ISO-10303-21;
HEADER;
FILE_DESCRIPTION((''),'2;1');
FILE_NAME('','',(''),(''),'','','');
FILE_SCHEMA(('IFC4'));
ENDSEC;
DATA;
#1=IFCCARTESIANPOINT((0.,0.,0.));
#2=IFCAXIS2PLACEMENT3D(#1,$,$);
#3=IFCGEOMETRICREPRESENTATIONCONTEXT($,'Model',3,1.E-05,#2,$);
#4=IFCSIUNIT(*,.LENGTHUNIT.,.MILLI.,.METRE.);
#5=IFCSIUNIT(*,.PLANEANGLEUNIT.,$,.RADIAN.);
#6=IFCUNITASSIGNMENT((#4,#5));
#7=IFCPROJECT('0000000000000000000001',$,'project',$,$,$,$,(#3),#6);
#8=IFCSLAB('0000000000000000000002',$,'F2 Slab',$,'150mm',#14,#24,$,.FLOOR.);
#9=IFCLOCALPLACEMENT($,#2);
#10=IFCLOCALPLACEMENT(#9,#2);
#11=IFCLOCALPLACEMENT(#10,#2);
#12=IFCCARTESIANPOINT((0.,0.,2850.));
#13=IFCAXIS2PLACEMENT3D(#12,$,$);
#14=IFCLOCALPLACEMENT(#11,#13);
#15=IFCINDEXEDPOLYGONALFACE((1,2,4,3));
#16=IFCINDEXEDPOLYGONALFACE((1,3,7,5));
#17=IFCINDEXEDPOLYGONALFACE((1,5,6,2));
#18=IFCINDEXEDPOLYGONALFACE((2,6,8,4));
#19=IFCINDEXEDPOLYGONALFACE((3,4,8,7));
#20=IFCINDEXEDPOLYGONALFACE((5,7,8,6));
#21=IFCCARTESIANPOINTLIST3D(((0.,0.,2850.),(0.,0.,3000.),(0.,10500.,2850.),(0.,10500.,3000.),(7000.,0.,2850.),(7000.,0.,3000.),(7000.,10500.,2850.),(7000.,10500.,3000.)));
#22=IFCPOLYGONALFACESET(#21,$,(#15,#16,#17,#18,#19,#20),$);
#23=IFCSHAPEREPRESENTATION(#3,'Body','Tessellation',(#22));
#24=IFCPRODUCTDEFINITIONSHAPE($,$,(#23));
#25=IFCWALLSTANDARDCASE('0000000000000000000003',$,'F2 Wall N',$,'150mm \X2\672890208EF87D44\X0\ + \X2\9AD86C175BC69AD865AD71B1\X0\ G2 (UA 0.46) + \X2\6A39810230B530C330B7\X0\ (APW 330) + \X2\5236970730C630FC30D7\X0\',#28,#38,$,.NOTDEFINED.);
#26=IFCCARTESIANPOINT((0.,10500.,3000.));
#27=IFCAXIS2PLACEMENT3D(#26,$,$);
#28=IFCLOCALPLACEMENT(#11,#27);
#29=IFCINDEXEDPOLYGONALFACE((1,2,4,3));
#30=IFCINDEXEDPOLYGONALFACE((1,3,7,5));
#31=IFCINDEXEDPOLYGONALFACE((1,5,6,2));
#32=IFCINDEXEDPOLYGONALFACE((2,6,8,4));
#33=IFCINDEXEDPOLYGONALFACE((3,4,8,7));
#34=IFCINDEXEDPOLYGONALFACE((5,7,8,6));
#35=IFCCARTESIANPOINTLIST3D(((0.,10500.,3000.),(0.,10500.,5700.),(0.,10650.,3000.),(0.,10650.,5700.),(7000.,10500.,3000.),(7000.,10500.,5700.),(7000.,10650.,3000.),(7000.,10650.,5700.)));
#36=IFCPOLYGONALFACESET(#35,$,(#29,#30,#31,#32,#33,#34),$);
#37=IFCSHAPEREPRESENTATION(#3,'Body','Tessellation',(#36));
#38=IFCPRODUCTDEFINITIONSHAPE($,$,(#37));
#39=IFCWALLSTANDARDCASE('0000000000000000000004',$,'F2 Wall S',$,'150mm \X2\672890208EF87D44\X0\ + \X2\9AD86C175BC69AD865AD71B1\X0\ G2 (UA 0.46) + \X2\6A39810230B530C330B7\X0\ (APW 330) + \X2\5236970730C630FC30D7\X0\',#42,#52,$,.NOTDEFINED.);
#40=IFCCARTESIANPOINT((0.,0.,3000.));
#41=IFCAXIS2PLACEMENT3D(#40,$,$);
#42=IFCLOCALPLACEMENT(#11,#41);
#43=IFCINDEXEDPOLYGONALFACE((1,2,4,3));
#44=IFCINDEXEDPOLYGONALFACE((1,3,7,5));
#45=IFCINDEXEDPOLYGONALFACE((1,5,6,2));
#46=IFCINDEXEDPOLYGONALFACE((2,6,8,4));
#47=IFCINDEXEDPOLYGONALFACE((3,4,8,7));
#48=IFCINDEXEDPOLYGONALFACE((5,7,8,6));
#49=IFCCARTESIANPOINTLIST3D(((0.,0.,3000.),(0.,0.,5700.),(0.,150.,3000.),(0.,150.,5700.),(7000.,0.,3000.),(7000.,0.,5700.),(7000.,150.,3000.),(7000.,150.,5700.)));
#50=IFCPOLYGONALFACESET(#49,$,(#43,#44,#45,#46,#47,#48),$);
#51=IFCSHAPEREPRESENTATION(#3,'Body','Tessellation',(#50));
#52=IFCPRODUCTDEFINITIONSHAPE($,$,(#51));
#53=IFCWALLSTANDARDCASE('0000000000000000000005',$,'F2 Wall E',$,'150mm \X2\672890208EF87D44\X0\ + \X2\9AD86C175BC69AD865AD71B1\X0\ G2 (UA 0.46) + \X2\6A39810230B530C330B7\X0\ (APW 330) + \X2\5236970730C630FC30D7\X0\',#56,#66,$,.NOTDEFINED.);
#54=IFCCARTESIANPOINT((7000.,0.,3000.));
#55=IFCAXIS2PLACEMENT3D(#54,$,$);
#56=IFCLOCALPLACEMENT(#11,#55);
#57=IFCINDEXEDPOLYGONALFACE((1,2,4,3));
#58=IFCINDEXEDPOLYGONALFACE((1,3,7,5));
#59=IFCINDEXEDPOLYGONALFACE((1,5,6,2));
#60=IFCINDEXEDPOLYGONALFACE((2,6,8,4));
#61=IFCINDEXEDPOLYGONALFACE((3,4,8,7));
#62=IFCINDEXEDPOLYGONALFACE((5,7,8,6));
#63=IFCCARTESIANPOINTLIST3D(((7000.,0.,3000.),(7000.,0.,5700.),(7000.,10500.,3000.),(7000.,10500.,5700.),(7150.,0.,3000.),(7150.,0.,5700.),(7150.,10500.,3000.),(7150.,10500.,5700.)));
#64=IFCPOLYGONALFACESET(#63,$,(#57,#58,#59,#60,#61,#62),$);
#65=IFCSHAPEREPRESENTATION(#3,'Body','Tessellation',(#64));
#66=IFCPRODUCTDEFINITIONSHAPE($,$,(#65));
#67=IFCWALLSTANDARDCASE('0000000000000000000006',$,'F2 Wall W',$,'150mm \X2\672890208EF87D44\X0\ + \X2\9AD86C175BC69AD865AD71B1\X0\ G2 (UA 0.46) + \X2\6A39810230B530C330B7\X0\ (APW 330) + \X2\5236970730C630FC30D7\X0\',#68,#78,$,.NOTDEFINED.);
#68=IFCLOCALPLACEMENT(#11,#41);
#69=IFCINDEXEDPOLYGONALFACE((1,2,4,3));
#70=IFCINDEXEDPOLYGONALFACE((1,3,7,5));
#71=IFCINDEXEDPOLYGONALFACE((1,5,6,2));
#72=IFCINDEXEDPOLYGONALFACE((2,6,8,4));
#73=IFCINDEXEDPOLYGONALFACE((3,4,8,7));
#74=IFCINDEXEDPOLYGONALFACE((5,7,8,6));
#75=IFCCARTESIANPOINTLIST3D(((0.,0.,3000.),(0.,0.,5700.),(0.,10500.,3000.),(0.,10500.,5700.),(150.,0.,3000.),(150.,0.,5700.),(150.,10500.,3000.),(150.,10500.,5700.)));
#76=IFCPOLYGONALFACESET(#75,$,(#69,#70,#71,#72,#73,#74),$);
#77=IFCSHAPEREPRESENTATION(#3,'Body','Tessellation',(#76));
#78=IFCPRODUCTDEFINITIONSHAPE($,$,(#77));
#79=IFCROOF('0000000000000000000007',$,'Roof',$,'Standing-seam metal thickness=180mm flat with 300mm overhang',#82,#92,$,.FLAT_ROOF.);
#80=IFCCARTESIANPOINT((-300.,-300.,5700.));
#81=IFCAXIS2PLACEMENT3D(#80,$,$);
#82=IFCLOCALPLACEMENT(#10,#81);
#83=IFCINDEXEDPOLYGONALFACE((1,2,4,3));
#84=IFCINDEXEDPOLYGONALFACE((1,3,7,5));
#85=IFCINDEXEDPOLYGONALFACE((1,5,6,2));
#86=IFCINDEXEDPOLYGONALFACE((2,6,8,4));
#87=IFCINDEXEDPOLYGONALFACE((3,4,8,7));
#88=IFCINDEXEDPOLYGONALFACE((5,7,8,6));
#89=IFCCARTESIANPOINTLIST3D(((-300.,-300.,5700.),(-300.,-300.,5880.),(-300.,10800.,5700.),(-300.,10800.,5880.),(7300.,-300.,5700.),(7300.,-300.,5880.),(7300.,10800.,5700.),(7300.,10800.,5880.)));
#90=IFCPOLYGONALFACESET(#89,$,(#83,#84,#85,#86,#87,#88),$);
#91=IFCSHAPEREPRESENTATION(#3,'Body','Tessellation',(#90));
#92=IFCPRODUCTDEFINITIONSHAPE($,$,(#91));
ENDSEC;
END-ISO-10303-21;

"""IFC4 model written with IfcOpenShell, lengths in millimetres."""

from ifc_helpers import new_model, si_unit, frame, frame_2d, origin, place, context, project, rectangle, extrude, element, save


model = new_model("IFC4")

# Units and contexts
model_context = context("Model", 3, precision=1e-05, world=origin())
ifc_project = project(units=[si_unit("LENGTHUNIT", "METRE", prefix="MILLI"), si_unit("PLANEANGLEUNIT", "RADIAN")], contexts=[model_context])

# Slab
placement_1 = place(None, origin())
placement_2 = place(placement_1, origin())
placement_3 = place(placement_2, origin())
slab_placement = place(placement_3, frame((0.0, 0.0, 2850.0)))
element("IfcSlab", 1, at=slab_placement, Name="F2 Slab", ObjectType="150mm", PredefinedType="FLOOR", context=model_context, shape_type="SweptSolid", body=[
    extrude(rectangle(XDim=7000.0, YDim=10500.0, at=frame_2d((3500.0, 5250.0))), frame((0.0, 0.0, 2850.0)), (0.0, 0.0, 1.0), 150.0),
])

# Walls
wall_1_placement = place(placement_3, frame((0.0, 10500.0, 3000.0)))
element("IfcWallStandardCase", 2, at=wall_1_placement, Name="F2 Wall N", ObjectType="150mm 木造軸組 + 高気密高断熱 G2 (UA 0.46) + 樹脂サッシ (APW 330) + 制震テープ", PredefinedType="NOTDEFINED", context=model_context, shape_type="SweptSolid", body=[
    extrude(rectangle(XDim=7000.0, YDim=150.0, at=frame_2d((3500.0, 75.0))), frame((0.0, 10500.0, 3000.0)), (0.0, 0.0, 1.0), 2700.0),
])
wall_2_placement = place(placement_3, frame((0.0, 0.0, 3000.0)))
element("IfcWallStandardCase", 3, at=wall_2_placement, Name="F2 Wall S", ObjectType="150mm 木造軸組 + 高気密高断熱 G2 (UA 0.46) + 樹脂サッシ (APW 330) + 制震テープ", PredefinedType="NOTDEFINED", context=model_context, shape_type="SweptSolid", body=[
    extrude(rectangle(XDim=7000.0, YDim=150.0, at=frame_2d((3500.0, 75.0))), frame((0.0, 0.0, 3000.0)), (0.0, 0.0, 1.0), 2700.0),
])
wall_3_placement = place(placement_3, frame((7000.0, 0.0, 3000.0)))
element("IfcWallStandardCase", 4, at=wall_3_placement, Name="F2 Wall E", ObjectType="150mm 木造軸組 + 高気密高断熱 G2 (UA 0.46) + 樹脂サッシ (APW 330) + 制震テープ", PredefinedType="NOTDEFINED", context=model_context, shape_type="SweptSolid", body=[
    extrude(rectangle(XDim=150.0, YDim=10500.0, at=frame_2d((75.0, 5250.0))), frame((7000.0, 0.0, 3000.0)), (0.0, 0.0, 1.0), 2700.0),
])
wall_4_placement = place(placement_3, frame((0.0, 0.0, 3000.0)))
element("IfcWallStandardCase", 5, at=wall_4_placement, Name="F2 Wall W", ObjectType="150mm 木造軸組 + 高気密高断熱 G2 (UA 0.46) + 樹脂サッシ (APW 330) + 制震テープ", PredefinedType="NOTDEFINED", context=model_context, shape_type="SweptSolid", body=[
    extrude(rectangle(XDim=150.0, YDim=10500.0, at=frame_2d((75.0, 5250.0))), frame((0.0, 0.0, 3000.0)), (0.0, 0.0, 1.0), 2700.0),
])

# Roof
roof_placement = place(placement_2, frame((-300.0, -300.0, 5700.0)))
element("IfcRoof", 6, at=roof_placement, Name="Roof", ObjectType="Standing-seam metal thickness=180mm flat with 300mm overhang", PredefinedType="FLAT_ROOF", context=model_context, shape_type="SweptSolid", body=[
    extrude(rectangle(XDim=7600.0, YDim=11100.0, at=frame_2d((3800.0, 5550.0))), frame((-300.0, -300.0, 5700.0)), (0.0, 0.0, 1.0), 180.0),
])

save(model, "model.ifc")
